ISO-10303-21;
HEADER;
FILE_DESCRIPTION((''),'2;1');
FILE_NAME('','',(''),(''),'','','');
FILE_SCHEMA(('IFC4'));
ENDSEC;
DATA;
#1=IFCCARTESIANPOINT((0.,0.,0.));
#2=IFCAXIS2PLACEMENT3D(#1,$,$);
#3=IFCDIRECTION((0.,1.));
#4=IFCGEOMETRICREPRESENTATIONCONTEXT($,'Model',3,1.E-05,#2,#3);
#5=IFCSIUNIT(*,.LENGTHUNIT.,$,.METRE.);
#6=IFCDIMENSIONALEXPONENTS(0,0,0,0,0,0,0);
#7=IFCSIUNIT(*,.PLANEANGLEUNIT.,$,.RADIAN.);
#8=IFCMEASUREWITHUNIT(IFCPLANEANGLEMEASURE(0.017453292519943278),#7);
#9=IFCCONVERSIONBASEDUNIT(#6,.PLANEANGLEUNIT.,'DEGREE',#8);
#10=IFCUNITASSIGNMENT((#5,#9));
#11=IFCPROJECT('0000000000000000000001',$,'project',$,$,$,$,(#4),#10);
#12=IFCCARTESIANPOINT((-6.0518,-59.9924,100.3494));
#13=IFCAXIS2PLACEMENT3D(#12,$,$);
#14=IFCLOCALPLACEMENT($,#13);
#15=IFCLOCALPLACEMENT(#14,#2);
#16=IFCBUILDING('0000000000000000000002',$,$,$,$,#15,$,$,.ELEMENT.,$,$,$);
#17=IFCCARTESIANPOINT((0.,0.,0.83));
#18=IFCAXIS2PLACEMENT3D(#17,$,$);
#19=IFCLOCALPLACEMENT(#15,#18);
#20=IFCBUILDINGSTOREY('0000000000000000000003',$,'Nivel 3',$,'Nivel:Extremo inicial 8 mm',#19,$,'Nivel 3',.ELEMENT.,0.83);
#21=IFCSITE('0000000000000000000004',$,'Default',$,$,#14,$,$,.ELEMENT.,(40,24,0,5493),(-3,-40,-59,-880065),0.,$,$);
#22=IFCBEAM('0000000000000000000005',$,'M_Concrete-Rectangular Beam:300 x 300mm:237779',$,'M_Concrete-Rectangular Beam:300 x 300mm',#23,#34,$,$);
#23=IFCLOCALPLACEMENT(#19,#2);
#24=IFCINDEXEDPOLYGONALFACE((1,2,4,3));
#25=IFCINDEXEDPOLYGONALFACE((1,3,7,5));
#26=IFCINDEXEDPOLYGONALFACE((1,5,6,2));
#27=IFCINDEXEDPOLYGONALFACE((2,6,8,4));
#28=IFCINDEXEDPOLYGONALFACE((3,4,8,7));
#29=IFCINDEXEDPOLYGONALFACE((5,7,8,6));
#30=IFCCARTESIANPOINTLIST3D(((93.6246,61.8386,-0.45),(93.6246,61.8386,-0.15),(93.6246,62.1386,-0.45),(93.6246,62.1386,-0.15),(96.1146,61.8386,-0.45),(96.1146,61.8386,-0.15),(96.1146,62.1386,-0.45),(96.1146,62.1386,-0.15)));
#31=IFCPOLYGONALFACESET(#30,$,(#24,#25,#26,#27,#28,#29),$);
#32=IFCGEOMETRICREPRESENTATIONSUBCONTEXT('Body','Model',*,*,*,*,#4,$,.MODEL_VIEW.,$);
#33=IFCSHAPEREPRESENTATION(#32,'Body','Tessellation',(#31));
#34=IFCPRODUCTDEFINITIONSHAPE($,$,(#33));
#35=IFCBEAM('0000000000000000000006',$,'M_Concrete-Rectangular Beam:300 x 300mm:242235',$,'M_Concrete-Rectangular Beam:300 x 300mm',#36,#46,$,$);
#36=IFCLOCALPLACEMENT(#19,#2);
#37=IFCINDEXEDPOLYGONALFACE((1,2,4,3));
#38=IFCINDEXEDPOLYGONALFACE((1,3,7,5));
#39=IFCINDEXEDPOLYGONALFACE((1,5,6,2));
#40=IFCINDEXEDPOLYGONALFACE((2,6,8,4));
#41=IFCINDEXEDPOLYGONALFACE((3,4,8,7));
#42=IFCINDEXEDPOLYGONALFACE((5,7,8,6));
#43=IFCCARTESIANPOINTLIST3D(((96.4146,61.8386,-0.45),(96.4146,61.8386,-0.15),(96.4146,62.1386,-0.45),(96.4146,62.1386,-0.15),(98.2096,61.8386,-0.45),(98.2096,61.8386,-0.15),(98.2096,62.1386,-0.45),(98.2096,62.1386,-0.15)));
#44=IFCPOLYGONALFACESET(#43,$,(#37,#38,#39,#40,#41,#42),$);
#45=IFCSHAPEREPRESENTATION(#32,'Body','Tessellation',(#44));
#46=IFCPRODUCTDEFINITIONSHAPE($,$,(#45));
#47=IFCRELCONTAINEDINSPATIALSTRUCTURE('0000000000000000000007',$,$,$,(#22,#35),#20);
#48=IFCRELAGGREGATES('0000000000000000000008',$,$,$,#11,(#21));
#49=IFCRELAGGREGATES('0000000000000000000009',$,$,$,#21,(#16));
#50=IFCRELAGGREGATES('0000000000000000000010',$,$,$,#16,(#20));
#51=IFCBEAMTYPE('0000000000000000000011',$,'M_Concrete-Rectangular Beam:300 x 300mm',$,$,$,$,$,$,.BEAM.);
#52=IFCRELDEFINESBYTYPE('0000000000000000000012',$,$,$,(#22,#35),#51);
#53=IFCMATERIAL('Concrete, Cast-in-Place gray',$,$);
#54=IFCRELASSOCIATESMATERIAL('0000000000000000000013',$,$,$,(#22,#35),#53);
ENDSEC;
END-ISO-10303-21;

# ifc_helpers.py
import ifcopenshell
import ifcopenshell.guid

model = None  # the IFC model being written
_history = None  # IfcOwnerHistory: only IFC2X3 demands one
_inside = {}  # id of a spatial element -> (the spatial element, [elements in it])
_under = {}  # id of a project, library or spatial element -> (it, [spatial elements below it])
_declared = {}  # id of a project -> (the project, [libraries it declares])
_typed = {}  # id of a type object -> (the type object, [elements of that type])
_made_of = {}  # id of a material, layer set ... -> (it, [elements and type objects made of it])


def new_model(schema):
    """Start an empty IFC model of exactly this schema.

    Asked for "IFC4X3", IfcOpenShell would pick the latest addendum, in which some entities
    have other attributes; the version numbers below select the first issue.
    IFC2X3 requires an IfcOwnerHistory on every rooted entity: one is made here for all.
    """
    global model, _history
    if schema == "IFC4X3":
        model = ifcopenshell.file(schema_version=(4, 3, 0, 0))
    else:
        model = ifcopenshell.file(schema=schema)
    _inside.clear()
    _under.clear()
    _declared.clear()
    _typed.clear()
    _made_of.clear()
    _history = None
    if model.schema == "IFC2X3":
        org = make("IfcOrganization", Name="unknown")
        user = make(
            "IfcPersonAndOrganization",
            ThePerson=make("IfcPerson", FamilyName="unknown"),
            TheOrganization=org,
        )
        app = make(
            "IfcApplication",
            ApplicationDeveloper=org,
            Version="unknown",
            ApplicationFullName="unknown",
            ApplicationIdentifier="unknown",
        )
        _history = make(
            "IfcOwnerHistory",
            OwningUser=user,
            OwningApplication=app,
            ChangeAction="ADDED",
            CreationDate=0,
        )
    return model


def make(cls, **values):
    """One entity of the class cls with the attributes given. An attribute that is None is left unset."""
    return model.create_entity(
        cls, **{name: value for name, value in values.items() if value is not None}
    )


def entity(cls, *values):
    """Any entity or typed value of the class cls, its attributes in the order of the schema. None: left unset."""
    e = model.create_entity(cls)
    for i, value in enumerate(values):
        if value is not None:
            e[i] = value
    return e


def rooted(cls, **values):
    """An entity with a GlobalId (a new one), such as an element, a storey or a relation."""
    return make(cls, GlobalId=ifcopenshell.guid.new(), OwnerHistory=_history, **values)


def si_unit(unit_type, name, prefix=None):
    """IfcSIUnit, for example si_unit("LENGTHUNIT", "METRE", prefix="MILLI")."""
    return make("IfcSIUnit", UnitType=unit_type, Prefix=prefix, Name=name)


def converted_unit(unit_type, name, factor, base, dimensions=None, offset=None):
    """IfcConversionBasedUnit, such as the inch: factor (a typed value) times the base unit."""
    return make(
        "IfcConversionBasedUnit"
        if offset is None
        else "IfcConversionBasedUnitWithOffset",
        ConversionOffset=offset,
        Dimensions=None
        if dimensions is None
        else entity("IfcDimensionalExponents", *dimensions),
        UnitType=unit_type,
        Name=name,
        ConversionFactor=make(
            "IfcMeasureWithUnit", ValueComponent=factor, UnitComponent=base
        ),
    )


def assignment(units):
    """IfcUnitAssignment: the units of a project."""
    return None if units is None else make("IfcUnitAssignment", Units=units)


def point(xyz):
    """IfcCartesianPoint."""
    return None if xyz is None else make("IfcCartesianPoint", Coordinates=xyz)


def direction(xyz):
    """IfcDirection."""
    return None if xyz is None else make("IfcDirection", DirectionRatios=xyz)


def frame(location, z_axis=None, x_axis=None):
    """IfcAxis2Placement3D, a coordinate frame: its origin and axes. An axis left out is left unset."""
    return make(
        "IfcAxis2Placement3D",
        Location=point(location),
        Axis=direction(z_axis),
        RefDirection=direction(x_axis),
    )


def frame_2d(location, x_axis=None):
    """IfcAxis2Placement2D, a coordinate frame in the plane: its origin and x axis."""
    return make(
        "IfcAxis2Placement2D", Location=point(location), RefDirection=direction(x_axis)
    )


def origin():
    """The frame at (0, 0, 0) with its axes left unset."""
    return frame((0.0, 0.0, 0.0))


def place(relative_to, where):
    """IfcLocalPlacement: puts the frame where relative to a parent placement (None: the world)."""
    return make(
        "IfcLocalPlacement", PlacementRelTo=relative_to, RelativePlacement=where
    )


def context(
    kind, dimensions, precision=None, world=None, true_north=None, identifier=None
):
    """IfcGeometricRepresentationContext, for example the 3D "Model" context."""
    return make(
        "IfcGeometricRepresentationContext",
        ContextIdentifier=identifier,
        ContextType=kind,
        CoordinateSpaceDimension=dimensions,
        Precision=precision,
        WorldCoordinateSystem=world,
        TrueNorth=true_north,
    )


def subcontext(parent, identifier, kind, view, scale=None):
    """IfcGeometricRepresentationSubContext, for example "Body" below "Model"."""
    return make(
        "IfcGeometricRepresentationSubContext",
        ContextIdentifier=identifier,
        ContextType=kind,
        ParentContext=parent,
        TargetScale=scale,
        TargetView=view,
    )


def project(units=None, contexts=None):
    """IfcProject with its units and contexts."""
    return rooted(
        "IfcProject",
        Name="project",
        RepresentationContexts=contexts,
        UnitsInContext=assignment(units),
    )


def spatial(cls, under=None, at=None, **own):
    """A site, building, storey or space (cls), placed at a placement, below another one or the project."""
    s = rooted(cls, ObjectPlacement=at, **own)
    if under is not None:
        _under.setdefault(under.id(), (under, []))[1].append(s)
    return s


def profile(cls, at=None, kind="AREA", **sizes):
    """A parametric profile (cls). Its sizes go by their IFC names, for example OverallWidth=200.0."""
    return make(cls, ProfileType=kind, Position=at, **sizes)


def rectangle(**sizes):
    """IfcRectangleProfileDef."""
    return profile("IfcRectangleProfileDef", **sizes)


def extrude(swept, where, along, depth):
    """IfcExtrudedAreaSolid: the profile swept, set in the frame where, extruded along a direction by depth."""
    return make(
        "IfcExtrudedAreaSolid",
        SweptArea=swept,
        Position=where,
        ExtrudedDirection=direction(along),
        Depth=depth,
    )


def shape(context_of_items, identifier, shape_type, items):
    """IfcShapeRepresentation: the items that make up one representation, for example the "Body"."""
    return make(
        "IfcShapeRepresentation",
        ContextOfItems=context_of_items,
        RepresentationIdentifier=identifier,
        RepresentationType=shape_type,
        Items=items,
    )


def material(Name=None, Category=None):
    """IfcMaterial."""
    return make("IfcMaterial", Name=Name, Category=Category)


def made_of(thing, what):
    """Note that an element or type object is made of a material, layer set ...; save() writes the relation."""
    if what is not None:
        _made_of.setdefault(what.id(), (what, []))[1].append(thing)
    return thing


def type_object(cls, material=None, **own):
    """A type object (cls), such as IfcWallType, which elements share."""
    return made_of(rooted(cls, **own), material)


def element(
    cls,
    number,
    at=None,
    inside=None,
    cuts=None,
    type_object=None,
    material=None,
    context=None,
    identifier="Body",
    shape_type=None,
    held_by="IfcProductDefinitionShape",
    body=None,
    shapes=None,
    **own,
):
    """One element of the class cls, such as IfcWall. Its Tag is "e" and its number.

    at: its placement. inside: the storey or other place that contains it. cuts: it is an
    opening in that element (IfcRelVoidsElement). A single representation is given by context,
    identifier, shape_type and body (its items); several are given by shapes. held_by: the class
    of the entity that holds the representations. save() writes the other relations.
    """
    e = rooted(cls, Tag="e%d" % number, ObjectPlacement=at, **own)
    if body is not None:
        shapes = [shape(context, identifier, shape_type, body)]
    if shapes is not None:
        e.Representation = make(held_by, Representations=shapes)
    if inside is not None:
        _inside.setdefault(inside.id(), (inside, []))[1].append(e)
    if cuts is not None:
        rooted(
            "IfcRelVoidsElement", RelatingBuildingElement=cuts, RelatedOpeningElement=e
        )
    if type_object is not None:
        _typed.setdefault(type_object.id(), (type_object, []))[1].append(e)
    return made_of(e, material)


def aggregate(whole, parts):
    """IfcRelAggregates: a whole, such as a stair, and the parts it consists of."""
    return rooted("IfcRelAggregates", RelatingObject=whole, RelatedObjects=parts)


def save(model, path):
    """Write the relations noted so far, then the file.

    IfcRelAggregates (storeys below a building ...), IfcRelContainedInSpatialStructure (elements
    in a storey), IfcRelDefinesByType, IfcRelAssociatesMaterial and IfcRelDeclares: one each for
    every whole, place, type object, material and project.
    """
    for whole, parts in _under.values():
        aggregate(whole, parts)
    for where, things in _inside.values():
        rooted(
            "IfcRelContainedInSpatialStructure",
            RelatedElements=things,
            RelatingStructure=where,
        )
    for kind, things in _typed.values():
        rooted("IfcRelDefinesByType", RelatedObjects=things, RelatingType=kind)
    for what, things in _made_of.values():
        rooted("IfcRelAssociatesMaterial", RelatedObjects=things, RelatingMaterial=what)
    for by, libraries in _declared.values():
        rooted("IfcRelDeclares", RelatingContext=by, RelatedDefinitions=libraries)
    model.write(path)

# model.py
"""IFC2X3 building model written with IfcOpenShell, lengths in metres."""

from ifc_helpers import new_model, entity, si_unit, converted_unit, direction, frame, frame_2d, origin, place, context, subcontext, project, spatial, rectangle, extrude, material, type_object, element, save


model = new_model("IFC2X3")

# Units and contexts
model_context = context("Model", 3, precision=1e-05, world=origin(), true_north=direction((0.0, 1.0)))
body_context = subcontext(model_context, "Body", "Model", "MODEL_VIEW")
ifc_project = project(units=[si_unit("LENGTHUNIT", "METRE"), converted_unit("PLANEANGLEUNIT", "DEGREE", entity("IfcPlaneAngleMeasure", 0.017453292519943278), si_unit("PLANEANGLEUNIT", "RADIAN"), dimensions=[0, 0, 0, 0, 0, 0, 0])], contexts=[model_context])

# Site, building, storey
site_placement = place(None, frame((-6.0518, -59.9924, 100.3494)))
site = spatial("IfcSite", under=ifc_project, at=site_placement, Name="Default", CompositionType="ELEMENT", RefLatitude=(40, 24, 0, 5493), RefLongitude=(-3, -40, -59, -880065), RefElevation=0.0)
building_placement = place(site_placement, origin())
building = spatial("IfcBuilding", under=site, at=building_placement, CompositionType="ELEMENT")
storey_placement = place(building_placement, frame((0.0, 0.0, 0.83)))
storey = spatial("IfcBuildingStorey", under=building, at=storey_placement, Name="Nivel 3", ObjectType="Nivel:Extremo inicial 8 mm", LongName="Nivel 3", CompositionType="ELEMENT", Elevation=0.83)

# Beams
ifc_material_1 = material(Name="Concrete, Cast-in-Place gray")
beam_type = type_object("IfcBeamType", Name="M_Concrete-Rectangular Beam:300 x 300mm", PredefinedType="BEAM")
beam_1_placement = place(storey_placement, frame((96.2646, 61.9886, 0.0), z_axis=(0.0, 0.0, 1.0), x_axis=(-1.0, 0.0, 0.0)))
element("IfcBeam", 1, at=beam_1_placement, inside=storey, type_object=beam_type, material=ifc_material_1, Name="M_Concrete-Rectangular Beam:300 x 300mm:237779", ObjectType="M_Concrete-Rectangular Beam:300 x 300mm", context=body_context, shape_type="SweptSolid", body=[
    extrude(rectangle(XDim=0.3, YDim=0.3, at=frame_2d((0.0, 0.0), x_axis=(1.0, 0.0))), frame((0.15, 0.0, -0.3), z_axis=(1.0, 0.0, 0.0), x_axis=(0.0, 0.0, -1.0)), (0.0, 0.0, 1.0), 2.49),
])
beam_2_placement = place(storey_placement, frame((96.2646, 61.9886, 0.0)))
element("IfcBeam", 2, at=beam_2_placement, inside=storey, type_object=beam_type, material=ifc_material_1, Name="M_Concrete-Rectangular Beam:300 x 300mm:242235", ObjectType="M_Concrete-Rectangular Beam:300 x 300mm", context=body_context, shape_type="SweptSolid", body=[
    extrude(rectangle(XDim=0.3, YDim=0.3, at=frame_2d((0.0, 0.0), x_axis=(1.0, 0.0))), frame((0.15, 0.0, -0.3), z_axis=(1.0, 0.0, 0.0), x_axis=(0.0, 0.0, -1.0)), (0.0, 0.0, 1.0), 1.795),
])

save(model, "model.ifc")
